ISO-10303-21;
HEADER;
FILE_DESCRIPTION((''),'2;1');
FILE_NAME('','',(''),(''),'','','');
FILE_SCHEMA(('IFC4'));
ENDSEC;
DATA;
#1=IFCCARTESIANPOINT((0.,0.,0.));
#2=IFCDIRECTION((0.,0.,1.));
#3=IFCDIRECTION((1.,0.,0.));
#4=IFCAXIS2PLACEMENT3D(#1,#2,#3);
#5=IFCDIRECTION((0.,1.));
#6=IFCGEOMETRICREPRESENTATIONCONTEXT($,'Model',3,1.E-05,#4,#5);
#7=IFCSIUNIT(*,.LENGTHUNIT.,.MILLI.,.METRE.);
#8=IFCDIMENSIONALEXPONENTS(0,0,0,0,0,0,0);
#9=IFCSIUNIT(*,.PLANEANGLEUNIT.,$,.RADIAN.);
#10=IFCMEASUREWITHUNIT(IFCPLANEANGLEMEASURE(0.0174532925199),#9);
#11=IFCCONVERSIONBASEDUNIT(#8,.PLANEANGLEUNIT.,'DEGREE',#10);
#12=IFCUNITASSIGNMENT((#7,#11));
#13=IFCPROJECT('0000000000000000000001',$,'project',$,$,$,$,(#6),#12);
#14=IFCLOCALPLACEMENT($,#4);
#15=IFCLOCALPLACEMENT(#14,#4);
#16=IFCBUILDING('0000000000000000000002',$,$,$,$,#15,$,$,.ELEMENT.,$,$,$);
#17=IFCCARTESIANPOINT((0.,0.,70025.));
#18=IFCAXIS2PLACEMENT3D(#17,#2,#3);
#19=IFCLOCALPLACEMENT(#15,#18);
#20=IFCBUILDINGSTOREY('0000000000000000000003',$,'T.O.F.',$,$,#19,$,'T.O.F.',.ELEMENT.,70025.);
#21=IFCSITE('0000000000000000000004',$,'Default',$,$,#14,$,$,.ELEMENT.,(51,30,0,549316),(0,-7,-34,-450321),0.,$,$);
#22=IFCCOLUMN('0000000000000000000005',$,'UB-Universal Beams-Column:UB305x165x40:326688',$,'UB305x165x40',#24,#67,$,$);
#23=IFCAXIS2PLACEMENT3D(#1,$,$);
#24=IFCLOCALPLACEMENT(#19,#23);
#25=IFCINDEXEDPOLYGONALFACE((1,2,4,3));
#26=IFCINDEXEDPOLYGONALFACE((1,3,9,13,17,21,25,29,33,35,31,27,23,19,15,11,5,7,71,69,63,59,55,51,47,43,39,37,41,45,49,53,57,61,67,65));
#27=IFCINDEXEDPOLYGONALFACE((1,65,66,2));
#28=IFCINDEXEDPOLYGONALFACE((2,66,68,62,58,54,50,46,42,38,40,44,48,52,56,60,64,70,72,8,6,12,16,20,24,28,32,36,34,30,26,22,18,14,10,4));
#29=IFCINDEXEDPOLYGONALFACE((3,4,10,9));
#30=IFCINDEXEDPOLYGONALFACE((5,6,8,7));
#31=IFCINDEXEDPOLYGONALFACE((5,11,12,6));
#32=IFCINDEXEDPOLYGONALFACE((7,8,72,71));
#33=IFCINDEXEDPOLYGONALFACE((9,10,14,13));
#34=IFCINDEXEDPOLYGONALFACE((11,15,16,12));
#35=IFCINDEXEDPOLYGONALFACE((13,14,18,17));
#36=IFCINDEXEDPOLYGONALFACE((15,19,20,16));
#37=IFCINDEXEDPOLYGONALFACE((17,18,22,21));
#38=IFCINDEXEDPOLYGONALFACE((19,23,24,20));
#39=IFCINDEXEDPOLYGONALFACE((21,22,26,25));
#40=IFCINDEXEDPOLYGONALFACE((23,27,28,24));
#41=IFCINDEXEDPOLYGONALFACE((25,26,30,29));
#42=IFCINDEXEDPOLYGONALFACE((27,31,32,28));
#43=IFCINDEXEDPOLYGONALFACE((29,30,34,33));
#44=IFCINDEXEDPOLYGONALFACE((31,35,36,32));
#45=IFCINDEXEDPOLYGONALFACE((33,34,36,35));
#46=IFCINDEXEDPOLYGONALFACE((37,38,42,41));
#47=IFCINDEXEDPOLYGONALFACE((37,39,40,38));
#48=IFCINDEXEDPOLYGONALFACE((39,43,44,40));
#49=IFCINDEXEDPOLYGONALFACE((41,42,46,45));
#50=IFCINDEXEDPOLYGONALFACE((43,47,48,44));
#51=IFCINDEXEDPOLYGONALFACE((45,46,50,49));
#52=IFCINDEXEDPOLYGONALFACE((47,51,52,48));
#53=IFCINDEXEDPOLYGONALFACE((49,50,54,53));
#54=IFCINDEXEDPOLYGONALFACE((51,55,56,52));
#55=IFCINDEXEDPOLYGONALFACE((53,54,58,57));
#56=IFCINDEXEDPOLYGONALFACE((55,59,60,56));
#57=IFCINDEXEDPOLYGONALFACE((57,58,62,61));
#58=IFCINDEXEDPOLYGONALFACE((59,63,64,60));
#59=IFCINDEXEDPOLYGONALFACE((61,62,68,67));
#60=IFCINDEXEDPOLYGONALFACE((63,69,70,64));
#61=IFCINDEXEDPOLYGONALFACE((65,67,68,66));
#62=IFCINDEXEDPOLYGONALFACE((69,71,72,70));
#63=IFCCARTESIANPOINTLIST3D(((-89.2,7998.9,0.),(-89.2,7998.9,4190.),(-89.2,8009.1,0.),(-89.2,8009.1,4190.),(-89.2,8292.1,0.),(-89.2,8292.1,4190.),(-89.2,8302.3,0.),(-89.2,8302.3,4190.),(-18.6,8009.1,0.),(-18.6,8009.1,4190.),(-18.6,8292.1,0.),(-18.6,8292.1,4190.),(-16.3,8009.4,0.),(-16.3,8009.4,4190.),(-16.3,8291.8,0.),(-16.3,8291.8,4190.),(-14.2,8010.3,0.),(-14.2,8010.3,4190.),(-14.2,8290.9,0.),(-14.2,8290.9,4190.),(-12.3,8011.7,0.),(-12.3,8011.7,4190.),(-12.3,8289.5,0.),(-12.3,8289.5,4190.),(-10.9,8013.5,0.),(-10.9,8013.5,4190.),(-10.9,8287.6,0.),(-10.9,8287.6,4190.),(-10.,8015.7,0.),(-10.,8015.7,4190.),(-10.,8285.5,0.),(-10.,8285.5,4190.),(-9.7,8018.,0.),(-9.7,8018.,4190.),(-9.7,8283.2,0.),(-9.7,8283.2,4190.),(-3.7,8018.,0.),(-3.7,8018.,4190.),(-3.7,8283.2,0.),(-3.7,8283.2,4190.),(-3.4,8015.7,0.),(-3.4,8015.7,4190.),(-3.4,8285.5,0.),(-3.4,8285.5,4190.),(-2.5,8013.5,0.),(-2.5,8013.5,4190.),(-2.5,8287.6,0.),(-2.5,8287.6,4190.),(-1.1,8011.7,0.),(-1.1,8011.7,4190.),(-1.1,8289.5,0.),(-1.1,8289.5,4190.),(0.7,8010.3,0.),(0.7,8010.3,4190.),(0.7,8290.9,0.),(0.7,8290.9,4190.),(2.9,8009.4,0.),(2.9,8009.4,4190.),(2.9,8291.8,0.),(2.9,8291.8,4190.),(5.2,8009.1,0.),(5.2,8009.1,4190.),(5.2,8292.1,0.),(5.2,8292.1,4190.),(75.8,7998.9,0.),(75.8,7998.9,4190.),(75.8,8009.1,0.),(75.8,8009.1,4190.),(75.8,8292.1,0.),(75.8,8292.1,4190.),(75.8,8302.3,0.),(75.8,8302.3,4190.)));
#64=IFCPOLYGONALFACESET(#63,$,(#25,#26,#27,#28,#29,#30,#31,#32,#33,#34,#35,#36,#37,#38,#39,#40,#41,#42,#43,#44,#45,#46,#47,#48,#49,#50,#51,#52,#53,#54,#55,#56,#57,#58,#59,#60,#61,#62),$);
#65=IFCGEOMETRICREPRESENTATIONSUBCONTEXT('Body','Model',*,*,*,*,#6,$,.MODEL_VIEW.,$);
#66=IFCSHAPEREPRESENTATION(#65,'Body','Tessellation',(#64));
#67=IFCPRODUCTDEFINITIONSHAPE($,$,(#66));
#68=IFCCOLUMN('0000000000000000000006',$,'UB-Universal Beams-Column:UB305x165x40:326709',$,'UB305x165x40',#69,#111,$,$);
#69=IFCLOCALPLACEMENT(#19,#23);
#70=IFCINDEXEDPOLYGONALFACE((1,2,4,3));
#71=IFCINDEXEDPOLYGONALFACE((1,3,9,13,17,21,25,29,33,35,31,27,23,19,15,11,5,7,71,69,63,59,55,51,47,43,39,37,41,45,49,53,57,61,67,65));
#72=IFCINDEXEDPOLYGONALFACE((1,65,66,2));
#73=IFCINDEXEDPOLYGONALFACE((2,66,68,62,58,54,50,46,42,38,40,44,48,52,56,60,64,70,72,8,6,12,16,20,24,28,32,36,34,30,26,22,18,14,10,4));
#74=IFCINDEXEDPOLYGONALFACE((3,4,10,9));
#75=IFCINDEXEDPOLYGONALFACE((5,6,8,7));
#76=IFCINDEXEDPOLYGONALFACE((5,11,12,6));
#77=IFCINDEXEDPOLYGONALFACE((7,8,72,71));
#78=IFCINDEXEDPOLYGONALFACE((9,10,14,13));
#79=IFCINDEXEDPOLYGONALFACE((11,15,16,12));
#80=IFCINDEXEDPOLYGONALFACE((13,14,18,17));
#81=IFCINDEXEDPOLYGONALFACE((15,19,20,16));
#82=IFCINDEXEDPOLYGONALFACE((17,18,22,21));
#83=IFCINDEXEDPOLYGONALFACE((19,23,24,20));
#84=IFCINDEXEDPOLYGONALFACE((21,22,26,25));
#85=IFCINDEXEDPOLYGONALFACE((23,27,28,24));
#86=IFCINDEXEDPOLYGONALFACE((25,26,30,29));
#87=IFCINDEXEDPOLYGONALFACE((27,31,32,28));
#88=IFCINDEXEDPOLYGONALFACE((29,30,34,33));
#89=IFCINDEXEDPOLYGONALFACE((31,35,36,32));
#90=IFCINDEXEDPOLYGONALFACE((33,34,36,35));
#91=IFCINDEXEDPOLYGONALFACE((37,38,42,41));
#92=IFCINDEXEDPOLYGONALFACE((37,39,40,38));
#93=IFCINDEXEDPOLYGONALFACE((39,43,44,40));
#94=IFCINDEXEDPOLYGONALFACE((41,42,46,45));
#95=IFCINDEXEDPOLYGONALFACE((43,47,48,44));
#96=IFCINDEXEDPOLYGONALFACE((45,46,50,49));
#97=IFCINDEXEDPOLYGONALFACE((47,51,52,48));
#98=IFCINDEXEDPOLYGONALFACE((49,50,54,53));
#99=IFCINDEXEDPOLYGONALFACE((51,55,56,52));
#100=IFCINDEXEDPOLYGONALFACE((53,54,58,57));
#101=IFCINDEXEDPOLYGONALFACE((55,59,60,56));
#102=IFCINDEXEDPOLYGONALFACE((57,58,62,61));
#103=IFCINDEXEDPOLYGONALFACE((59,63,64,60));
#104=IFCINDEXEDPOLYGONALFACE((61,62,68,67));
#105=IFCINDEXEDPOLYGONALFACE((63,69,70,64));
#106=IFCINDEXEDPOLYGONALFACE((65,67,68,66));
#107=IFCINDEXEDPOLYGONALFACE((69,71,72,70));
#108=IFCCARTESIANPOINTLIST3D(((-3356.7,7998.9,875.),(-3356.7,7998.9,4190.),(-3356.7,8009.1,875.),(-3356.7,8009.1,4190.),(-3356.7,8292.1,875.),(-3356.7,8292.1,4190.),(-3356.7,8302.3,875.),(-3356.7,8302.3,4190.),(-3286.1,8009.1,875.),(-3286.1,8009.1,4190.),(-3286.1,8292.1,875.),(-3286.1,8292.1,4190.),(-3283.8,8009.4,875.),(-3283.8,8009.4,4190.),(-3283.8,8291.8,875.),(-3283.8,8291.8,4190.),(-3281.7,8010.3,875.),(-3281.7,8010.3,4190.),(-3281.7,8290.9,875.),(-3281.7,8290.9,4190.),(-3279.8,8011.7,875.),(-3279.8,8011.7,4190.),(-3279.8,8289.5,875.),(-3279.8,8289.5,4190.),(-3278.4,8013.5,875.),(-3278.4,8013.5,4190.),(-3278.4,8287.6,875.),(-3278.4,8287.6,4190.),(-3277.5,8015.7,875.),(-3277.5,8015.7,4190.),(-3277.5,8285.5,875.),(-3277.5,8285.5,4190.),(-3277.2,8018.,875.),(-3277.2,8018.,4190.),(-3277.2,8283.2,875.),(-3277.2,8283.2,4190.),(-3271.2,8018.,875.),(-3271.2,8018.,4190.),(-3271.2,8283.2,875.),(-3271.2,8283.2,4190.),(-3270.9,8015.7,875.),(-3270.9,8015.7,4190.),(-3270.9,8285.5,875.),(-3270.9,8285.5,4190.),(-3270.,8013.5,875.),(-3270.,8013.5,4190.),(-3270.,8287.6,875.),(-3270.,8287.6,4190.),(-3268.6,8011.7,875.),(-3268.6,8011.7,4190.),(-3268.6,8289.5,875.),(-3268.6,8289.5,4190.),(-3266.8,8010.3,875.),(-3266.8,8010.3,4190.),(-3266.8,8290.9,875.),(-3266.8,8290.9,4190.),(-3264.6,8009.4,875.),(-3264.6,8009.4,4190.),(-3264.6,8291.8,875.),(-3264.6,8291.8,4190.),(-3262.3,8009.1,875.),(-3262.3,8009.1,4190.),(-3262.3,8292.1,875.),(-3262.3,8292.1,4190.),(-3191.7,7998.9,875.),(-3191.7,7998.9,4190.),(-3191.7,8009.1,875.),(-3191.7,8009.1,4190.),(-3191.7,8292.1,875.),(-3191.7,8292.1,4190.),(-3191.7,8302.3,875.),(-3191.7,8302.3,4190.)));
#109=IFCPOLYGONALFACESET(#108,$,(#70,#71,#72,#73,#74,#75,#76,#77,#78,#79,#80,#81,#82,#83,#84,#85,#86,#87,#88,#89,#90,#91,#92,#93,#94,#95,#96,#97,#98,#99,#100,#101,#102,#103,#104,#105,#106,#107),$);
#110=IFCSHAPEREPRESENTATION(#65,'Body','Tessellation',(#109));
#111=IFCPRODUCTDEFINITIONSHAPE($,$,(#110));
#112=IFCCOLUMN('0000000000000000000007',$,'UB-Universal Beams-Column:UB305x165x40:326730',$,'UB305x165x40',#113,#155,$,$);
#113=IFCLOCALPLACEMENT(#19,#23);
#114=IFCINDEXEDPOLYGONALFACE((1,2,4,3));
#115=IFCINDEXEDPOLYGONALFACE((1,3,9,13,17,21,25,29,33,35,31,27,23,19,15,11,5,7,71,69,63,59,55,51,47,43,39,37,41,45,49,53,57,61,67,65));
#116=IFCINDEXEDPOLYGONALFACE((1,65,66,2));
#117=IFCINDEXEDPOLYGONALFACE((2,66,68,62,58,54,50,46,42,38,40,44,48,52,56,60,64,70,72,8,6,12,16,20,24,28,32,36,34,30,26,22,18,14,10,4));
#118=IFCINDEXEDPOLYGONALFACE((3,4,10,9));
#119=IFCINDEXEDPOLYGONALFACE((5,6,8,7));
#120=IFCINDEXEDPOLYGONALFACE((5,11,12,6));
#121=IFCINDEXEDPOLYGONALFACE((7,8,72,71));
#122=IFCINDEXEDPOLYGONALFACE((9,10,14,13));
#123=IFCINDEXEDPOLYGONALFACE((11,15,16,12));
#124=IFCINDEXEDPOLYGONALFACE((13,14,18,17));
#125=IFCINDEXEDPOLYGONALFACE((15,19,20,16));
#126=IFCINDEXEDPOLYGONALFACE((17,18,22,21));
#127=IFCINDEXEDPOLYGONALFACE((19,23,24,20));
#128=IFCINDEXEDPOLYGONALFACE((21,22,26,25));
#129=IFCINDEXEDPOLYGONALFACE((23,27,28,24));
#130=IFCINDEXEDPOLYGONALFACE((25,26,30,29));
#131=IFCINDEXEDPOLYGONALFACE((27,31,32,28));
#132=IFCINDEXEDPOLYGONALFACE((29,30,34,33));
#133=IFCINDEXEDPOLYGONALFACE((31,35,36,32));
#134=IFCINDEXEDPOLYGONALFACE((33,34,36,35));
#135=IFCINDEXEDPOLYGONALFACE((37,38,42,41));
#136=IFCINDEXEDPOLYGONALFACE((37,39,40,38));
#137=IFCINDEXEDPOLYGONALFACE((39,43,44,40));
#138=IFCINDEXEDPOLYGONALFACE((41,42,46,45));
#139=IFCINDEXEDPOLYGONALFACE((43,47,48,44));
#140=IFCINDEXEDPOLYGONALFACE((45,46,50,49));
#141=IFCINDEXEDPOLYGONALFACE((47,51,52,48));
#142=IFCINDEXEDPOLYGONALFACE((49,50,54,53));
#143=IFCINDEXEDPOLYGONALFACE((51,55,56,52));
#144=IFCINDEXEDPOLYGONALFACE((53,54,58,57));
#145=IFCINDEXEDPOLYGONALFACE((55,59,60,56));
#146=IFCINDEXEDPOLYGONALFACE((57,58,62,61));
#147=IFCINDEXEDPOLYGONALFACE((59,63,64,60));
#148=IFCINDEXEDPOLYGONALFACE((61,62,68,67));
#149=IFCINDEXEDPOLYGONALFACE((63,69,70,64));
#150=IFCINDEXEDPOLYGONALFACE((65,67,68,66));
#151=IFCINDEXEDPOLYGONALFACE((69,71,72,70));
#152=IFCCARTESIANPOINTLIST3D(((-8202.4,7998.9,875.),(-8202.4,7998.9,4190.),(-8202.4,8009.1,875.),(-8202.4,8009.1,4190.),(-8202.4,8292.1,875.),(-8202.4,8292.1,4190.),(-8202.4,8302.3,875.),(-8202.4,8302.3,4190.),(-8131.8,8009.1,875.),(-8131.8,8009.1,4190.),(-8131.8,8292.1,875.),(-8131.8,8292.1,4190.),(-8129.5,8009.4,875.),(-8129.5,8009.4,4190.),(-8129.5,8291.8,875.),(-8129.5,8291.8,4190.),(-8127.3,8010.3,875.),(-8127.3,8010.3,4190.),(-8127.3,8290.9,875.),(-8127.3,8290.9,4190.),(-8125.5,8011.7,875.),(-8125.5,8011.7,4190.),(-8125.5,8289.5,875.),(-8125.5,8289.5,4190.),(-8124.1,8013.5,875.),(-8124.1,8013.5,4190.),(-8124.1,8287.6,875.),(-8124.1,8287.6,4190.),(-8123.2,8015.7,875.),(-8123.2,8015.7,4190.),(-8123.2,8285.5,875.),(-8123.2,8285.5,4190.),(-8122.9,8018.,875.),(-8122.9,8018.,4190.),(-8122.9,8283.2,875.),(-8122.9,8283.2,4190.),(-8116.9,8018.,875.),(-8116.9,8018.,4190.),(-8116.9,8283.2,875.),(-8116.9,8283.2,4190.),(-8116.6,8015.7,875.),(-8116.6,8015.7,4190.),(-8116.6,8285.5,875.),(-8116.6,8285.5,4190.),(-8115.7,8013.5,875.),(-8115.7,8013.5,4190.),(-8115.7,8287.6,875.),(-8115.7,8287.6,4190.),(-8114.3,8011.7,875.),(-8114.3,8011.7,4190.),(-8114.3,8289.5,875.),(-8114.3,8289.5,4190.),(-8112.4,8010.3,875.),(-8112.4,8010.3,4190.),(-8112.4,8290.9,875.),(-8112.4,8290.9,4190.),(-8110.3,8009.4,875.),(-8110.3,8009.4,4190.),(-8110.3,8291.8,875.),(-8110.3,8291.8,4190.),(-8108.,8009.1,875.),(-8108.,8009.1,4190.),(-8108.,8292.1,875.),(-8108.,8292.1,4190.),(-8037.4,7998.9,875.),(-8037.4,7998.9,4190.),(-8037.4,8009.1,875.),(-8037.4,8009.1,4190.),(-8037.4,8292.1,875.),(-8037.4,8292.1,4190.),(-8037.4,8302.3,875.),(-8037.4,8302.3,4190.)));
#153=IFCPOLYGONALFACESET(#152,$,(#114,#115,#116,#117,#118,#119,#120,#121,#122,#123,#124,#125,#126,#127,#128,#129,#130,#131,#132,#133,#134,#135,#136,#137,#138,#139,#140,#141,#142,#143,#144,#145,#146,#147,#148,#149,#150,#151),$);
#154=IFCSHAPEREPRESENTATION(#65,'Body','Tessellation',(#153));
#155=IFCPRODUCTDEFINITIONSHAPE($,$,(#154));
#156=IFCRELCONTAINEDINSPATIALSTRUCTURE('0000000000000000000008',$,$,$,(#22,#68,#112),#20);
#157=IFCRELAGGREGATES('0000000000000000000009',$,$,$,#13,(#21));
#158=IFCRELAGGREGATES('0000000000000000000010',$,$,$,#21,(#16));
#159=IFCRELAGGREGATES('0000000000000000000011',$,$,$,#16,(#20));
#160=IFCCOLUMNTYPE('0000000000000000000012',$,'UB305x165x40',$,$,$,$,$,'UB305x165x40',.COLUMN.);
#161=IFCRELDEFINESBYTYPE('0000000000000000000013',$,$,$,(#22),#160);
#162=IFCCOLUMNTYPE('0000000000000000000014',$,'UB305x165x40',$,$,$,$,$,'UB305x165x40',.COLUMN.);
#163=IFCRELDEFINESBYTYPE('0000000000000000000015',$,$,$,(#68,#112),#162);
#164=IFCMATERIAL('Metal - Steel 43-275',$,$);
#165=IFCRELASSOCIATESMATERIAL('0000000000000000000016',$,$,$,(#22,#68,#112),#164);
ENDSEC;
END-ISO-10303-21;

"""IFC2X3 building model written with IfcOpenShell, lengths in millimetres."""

from ifc_helpers import new_model, entity, si_unit, converted_unit, point, direction, frame, frame_2d, origin_with_axes, place, context, subcontext, project, spatial, polyline, circle_curve, parameter, trimmed, segment, composite_curve, outline, extrude, material, type_object, element, save


model = new_model("IFC2X3")

# Units and contexts
model_context = context("Model", 3, precision=1e-05, world=origin_with_axes(), true_north=direction((0.0, 1.0)))
body_context = subcontext(model_context, "Body", "Model", "MODEL_VIEW")
ifc_project = project(units=[si_unit("LENGTHUNIT", "METRE", prefix="MILLI"), converted_unit("PLANEANGLEUNIT", "DEGREE", entity("IfcPlaneAngleMeasure", 0.0174532925199), si_unit("PLANEANGLEUNIT", "RADIAN"), dimensions=[0, 0, 0, 0, 0, 0, 0])], contexts=[model_context])

# Site, building, storey
site_placement = place(None, origin_with_axes())
site = spatial("IfcSite", under=ifc_project, at=site_placement, Name="Default", CompositionType="ELEMENT", RefLatitude=(51, 30, 0, 549316), RefLongitude=(0, -7, -34, -450321), RefElevation=0.0)
building_placement = place(site_placement, origin_with_axes())
building = spatial("IfcBuilding", under=site, at=building_placement, CompositionType="ELEMENT")
storey_placement = place(building_placement, frame((0.0, 0.0, 70025.0), z_axis=(0.0, 0.0, 1.0), x_axis=(1.0, 0.0, 0.0)))
storey = spatial("IfcBuildingStorey", under=building, at=storey_placement, Name="T.O.F.", LongName="T.O.F.", CompositionType="ELEMENT", Elevation=70025.0)

# Columns
ifc_material_1 = material(Name="Metal - Steel 43-275")
column_type_1 = type_object("IfcColumnType", Name="UB305x165x40", ElementType="UB305x165x40", PredefinedType="COLUMN")
for number, where, z_axis, x_axis, name in (
    (1, (-6.7, 8150.6, 0.0), (0.0, 0.0, 1.0), (0.0, -1.0, 0.0), "UB-Universal Beams-Column:UB305x165x40:326688"),
):
    element("IfcColumn", number, at=place(storey_placement, frame(where, z_axis=z_axis, x_axis=x_axis)), inside=storey, type_object=column_type_1, material=ifc_material_1, Name=name, ObjectType="UB305x165x40", context=body_context, shape_type="SweptSolid", body=[
        extrude(outline(composite_curve([segment(polyline([(141.5, -82.5), (151.7, -82.5), (151.7, 82.5), (141.5, 82.5), (141.5, 11.9)]), True, "CONTINUOUS"), segment(trimmed(circle_curve(frame_2d((132.6, 11.9), x_axis=(0.0, -1.0)), 8.9), [point((141.5, 11.9)), parameter(90.0)], [point((132.6, 3.0)), parameter(0.0)], False, "CARTESIAN"), True, "CONTINUOUS"), segment(polyline([(132.6, 3.0), (-132.6, 3.0)]), True, "CONTINUOUS"), segment(trimmed(circle_curve(frame_2d((-132.6, 11.9), x_axis=(-1.0, 0.0)), 8.9), [point((-132.6, 3.0)), parameter(90.0)], [point((-141.5, 11.9)), parameter(0.0)], False, "CARTESIAN"), True, "CONTINUOUS"), segment(polyline([(-141.5, 11.9), (-141.5, 82.5), (-151.7, 82.5), (-151.7, -82.5), (-141.5, -82.5), (-141.5, -11.9)]), True, "CONTINUOUS"), segment(trimmed(circle_curve(frame_2d((-132.6, -11.9), x_axis=(0.0, 1.0)), 8.9), [point((-141.5, -11.9)), parameter(90.0)], [point((-132.6, -3.0)), parameter(0.0)], False, "CARTESIAN"), True, "CONTINUOUS"), segment(polyline([(-132.6, -3.0), (132.6, -3.0)]), True, "CONTINUOUS"), segment(trimmed(circle_curve(frame_2d((132.6, -11.9), x_axis=(1.0, 0.0)), 8.9), [point((132.6, -3.0)), parameter(90.0)], [point((141.5, -11.9)), parameter(0.0)], False, "CARTESIAN"), True, "CONTINUOUS"), segment(polyline([(141.5, -11.9), (141.5, -82.5)]), True, "CONTINUOUS")], self_intersect=False)), origin_with_axes(), (0.0, 0.0, 1.0), 4190.0),
    ])
column_type_2 = type_object("IfcColumnType", Name="UB305x165x40", ElementType="UB305x165x40", PredefinedType="COLUMN")
for number, where, z_axis, x_axis, name in (
    (2, (-3274.2, 8150.6, 875.0), (0.0, 0.0, 1.0), (0.0, -1.0, 0.0), "UB-Universal Beams-Column:UB305x165x40:326709"),
    (3, (-8119.9, 8150.6, 875.0), (0.0, 0.0, 1.0), (0.0, -1.0, 0.0), "UB-Universal Beams-Column:UB305x165x40:326730"),
):
    element("IfcColumn", number, at=place(storey_placement, frame(where, z_axis=z_axis, x_axis=x_axis)), inside=storey, type_object=column_type_2, material=ifc_material_1, Name=name, ObjectType="UB305x165x40", context=body_context, shape_type="SweptSolid", body=[
        extrude(outline(composite_curve([segment(polyline([(141.5, -82.5), (151.7, -82.5), (151.7, 82.5), (141.5, 82.5), (141.5, 11.9)]), True, "CONTINUOUS"), segment(trimmed(circle_curve(frame_2d((132.6, 11.9), x_axis=(0.0, -1.0)), 8.9), [point((141.5, 11.9)), parameter(90.0)], [point((132.6, 3.0)), parameter(0.0)], False, "CARTESIAN"), True, "CONTINUOUS"), segment(polyline([(132.6, 3.0), (-132.6, 3.0)]), True, "CONTINUOUS"), segment(trimmed(circle_curve(frame_2d((-132.6, 11.9), x_axis=(-1.0, 0.0)), 8.9), [point((-132.6, 3.0)), parameter(90.0)], [point((-141.5, 11.9)), parameter(0.0)], False, "CARTESIAN"), True, "CONTINUOUS"), segment(polyline([(-141.5, 11.9), (-141.5, 82.5), (-151.7, 82.5), (-151.7, -82.5), (-141.5, -82.5), (-141.5, -11.9)]), True, "CONTINUOUS"), segment(trimmed(circle_curve(frame_2d((-132.6, -11.9), x_axis=(0.0, 1.0)), 8.9), [point((-141.5, -11.9)), parameter(90.0)], [point((-132.6, -3.0)), parameter(0.0)], False, "CARTESIAN"), True, "CONTINUOUS"), segment(polyline([(-132.6, -3.0), (132.6, -3.0)]), True, "CONTINUOUS"), segment(trimmed(circle_curve(frame_2d((132.6, -11.9), x_axis=(1.0, 0.0)), 8.9), [point((132.6, -3.0)), parameter(90.0)], [point((141.5, -11.9)), parameter(0.0)], False, "CARTESIAN"), True, "CONTINUOUS"), segment(polyline([(141.5, -11.9), (141.5, -82.5)]), True, "CONTINUOUS")], self_intersect=False)), origin_with_axes(), (0.0, 0.0, 1.0), 3315.0),
    ])

save(model, "model.ifc")
